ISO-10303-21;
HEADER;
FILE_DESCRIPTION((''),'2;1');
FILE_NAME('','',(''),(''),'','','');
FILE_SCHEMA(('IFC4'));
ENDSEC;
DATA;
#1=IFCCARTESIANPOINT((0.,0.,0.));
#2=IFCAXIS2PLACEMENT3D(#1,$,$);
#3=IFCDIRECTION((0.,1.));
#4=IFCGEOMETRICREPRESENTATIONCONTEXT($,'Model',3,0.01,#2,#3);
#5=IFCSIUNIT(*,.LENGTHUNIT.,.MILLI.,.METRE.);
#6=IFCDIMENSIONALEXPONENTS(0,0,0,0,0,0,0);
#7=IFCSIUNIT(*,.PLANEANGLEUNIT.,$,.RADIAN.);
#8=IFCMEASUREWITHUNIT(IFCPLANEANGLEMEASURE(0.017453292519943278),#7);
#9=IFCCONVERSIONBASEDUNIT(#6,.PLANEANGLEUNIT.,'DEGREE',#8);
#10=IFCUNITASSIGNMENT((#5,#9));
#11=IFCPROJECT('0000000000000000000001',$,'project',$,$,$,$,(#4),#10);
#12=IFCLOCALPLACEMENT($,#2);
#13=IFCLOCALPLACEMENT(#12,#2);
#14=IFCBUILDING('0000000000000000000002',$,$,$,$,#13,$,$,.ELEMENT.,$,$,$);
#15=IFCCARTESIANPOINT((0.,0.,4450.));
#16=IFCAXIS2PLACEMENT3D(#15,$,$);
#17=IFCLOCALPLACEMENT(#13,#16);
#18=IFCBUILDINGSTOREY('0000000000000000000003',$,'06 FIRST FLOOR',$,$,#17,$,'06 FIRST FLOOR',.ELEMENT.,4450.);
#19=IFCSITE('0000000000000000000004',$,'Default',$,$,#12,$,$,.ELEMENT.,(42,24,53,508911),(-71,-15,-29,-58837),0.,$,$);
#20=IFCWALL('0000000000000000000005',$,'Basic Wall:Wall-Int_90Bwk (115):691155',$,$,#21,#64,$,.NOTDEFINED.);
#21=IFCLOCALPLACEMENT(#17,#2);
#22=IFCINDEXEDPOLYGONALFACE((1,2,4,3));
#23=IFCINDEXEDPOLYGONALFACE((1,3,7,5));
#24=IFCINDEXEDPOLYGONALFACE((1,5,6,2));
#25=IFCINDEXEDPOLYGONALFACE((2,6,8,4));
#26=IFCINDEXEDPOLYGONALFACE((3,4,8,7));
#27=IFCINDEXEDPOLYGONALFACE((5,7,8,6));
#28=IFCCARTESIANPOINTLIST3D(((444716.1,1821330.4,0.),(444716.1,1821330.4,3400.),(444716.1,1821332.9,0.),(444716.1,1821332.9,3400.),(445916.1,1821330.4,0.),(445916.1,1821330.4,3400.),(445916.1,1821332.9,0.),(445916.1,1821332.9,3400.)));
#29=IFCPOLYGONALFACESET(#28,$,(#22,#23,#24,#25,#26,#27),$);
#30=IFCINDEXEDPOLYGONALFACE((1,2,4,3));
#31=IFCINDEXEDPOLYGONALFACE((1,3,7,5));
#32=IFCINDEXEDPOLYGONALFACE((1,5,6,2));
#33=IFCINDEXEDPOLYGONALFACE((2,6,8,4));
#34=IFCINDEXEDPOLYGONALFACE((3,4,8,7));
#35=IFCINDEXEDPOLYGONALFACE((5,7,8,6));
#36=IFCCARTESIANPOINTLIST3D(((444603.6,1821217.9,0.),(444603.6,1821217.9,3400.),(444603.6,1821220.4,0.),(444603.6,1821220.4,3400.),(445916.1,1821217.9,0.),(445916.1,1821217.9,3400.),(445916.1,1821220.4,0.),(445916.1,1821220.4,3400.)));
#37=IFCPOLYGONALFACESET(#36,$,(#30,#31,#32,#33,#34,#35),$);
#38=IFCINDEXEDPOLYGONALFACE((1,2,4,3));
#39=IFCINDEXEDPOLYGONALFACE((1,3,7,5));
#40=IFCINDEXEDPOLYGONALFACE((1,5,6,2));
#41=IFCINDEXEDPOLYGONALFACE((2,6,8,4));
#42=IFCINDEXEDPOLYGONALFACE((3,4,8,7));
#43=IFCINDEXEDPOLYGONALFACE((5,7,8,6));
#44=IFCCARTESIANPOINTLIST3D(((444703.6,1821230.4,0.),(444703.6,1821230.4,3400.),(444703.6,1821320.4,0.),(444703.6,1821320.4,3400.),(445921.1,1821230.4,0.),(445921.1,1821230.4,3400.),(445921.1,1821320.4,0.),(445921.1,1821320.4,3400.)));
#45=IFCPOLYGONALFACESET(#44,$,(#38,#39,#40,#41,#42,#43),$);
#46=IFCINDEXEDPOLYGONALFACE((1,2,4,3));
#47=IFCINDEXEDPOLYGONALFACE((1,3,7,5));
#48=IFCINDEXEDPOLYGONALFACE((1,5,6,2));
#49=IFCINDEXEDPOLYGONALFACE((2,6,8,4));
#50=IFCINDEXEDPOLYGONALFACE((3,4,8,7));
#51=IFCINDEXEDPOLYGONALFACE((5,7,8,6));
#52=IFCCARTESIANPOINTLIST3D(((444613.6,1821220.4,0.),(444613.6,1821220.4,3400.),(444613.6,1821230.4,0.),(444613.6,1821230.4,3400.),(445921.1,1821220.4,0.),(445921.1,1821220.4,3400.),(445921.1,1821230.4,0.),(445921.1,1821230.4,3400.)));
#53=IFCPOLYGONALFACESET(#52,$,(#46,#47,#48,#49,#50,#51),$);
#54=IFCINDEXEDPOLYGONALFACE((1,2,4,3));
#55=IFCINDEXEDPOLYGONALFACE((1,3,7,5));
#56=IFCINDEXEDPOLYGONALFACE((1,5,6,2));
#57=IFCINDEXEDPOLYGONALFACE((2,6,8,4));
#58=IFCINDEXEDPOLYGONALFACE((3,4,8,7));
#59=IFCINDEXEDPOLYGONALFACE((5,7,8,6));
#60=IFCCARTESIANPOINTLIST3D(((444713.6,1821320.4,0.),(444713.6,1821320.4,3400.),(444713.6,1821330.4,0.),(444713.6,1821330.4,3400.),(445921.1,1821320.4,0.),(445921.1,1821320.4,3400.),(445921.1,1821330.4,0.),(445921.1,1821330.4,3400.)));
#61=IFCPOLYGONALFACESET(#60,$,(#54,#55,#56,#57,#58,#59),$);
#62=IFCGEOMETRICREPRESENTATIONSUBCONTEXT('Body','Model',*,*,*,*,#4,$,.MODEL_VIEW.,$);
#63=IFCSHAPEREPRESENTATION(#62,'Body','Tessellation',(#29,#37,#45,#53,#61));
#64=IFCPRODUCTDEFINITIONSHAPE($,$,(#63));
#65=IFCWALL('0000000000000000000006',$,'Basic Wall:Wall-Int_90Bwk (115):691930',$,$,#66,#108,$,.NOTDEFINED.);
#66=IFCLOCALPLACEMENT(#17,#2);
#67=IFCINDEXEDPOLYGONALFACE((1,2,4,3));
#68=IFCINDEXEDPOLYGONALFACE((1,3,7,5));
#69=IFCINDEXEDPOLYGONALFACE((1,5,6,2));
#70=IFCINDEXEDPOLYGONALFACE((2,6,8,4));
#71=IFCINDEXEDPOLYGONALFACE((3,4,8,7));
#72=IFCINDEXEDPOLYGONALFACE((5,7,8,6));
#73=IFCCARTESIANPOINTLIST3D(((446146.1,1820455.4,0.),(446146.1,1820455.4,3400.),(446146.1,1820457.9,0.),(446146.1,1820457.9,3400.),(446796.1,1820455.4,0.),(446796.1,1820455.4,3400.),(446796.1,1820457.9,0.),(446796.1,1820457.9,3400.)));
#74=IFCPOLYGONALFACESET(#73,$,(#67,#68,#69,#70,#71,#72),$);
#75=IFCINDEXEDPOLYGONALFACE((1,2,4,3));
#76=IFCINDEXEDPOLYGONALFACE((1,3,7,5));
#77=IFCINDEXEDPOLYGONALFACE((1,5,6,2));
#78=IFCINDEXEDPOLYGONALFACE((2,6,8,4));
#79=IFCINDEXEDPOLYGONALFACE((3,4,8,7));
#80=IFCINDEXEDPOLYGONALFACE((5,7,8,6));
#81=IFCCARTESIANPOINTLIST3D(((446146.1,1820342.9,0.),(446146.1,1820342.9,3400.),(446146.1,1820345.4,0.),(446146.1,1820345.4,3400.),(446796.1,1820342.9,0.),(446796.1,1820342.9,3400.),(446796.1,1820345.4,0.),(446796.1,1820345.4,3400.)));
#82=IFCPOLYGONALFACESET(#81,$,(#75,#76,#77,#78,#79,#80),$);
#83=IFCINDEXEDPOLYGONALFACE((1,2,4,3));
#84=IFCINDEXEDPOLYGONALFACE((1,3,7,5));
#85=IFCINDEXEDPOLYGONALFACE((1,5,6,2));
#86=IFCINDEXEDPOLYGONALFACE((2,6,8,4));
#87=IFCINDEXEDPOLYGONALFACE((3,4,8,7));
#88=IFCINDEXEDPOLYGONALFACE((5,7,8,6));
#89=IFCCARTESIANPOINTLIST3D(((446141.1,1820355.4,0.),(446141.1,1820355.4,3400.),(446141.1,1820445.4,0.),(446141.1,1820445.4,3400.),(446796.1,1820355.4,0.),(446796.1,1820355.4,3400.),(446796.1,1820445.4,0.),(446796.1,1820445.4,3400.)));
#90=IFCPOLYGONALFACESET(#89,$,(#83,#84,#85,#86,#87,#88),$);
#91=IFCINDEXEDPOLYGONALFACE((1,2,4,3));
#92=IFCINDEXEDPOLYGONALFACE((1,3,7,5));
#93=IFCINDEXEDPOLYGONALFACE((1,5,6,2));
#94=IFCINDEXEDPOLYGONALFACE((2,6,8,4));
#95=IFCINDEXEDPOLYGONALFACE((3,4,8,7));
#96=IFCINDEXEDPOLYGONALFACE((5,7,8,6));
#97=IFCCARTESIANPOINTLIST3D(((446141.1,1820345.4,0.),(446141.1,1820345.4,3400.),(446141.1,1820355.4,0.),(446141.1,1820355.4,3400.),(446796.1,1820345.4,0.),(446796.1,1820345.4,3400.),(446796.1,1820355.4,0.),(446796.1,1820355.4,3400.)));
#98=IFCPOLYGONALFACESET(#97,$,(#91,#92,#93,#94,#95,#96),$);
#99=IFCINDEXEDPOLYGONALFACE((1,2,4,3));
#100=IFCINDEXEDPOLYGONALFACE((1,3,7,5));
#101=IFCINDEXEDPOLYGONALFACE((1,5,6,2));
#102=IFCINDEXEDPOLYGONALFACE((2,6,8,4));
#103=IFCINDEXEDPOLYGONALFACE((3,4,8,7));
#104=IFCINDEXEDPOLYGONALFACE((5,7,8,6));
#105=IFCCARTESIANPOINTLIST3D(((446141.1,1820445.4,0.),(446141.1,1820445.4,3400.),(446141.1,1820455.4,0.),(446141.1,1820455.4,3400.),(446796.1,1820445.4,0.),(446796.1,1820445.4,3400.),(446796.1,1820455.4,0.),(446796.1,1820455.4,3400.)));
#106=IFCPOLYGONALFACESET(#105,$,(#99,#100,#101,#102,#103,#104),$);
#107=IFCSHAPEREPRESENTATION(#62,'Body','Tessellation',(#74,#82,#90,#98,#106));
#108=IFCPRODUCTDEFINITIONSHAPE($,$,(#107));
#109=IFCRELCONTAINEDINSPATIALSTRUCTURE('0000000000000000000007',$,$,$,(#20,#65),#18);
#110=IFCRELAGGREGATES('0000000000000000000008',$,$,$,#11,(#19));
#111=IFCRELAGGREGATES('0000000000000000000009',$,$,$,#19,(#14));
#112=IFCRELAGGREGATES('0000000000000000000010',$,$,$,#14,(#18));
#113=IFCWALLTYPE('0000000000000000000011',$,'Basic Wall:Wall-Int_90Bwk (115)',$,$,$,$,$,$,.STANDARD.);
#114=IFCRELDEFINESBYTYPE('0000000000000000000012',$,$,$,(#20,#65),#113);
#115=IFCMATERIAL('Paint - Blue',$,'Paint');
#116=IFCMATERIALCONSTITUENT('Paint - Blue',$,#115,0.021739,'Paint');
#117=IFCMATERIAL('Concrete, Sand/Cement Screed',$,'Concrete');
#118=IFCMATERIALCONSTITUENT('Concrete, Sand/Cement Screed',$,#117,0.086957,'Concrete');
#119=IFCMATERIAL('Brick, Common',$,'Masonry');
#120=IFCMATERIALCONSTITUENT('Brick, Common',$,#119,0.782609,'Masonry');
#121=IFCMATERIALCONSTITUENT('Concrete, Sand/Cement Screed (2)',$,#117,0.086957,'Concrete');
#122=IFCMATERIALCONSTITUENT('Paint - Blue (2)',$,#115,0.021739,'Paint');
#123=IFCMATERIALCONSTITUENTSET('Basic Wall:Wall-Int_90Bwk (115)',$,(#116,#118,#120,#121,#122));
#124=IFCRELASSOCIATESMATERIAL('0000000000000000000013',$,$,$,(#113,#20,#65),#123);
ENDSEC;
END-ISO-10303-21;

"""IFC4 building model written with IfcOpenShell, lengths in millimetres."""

from ifc_helpers import new_model, entity, si_unit, converted_unit, direction, frame, origin, place, context, subcontext, project, spatial, indexed_curve, outline, extrude, material, constituent, constituent_set, type_object, element, save


model = new_model("IFC4")

# Units and contexts
model_context = context("Model", 3, precision=0.01, world=origin(), true_north=direction((0.0, 1.0)))
body_context = subcontext(model_context, "Body", "Model", "MODEL_VIEW")
ifc_project = project(units=[si_unit("LENGTHUNIT", "METRE", prefix="MILLI"), converted_unit("PLANEANGLEUNIT", "DEGREE", entity("IfcPlaneAngleMeasure", 0.017453292519943278), si_unit("PLANEANGLEUNIT", "RADIAN"), dimensions=[0, 0, 0, 0, 0, 0, 0])], contexts=[model_context])

# Site, building, storey
site_placement = place(None, origin())
site = spatial("IfcSite", under=ifc_project, at=site_placement, Name="Default", CompositionType="ELEMENT", RefLatitude=(42, 24, 53, 508911), RefLongitude=(-71, -15, -29, -58837), RefElevation=0.0)
building_placement = place(site_placement, origin())
building = spatial("IfcBuilding", under=site, at=building_placement, CompositionType="ELEMENT")
storey_placement = place(building_placement, frame((0.0, 0.0, 4450.0)))
storey = spatial("IfcBuildingStorey", under=building, at=storey_placement, Name="06 FIRST FLOOR", LongName="06 FIRST FLOOR", CompositionType="ELEMENT", Elevation=4450.0)

# Shared definitions
ifc_material_1 = material(Name="Paint - Blue", Category="Paint")
ifc_constituent_1 = constituent(ifc_material_1, Name="Paint - Blue", Category="Paint", fraction=0.021739)
ifc_material_2 = material(Name="Concrete, Sand/Cement Screed", Category="Concrete")
ifc_constituent_2 = constituent(ifc_material_2, Name="Concrete, Sand/Cement Screed", Category="Concrete", fraction=0.086957)
ifc_material_3 = material(Name="Brick, Common", Category="Masonry")
ifc_constituent_3 = constituent(ifc_material_3, Name="Brick, Common", Category="Masonry", fraction=0.782609)
ifc_constituent_4 = constituent(ifc_material_2, Name="Concrete, Sand/Cement Screed (2)", Category="Concrete", fraction=0.086957)
ifc_constituent_5 = constituent(ifc_material_1, Name="Paint - Blue (2)", Category="Paint", fraction=0.021739)
ifc_constituent_set_1 = constituent_set(constituents=[ifc_constituent_1, ifc_constituent_2, ifc_constituent_3, ifc_constituent_4, ifc_constituent_5], Name="Basic Wall:Wall-Int_90Bwk (115)")
wall_type_1 = type_object("IfcWallType", Name="Basic Wall:Wall-Int_90Bwk (115)", PredefinedType="STANDARD", material=ifc_constituent_set_1)

# Wall
wall_1_placement = place(storey_placement, frame((445916.1, 1821275.4, 0.0), z_axis=(0.0, 0.0, 1.0), x_axis=(-1.0, 0.0, 0.0)))
element("IfcWall", 1, at=wall_1_placement, inside=storey, type_object=wall_type_1, material=ifc_constituent_set_1, Name="Basic Wall:Wall-Int_90Bwk (115):691155", PredefinedType="NOTDEFINED", context=body_context, shape_type="SweptSolid", body=[
    extrude(outline(indexed_curve([(-1.3, -600.0), (1.2, -600.0), (1.2, 600.0), (-1.3, 600.0), (-1.3, -600.0)], self_intersect=False)), frame((600.0, -56.2, 0.0), z_axis=(0.0, 0.0, 1.0), x_axis=(0.0, 1.0, 0.0)), (0.0, 0.0, 1.0), 3400.0),
    extrude(outline(indexed_curve([(-1.3, -656.2), (1.3, -656.2), (1.3, 656.2), (-1.3, 656.2), (-1.3, -656.2)], self_intersect=False)), frame((656.2, 56.3, 0.0), z_axis=(0.0, 0.0, 1.0), x_axis=(0.0, -1.0, 0.0)), (0.0, 0.0, 1.0), 3400.0),
    extrude(outline(indexed_curve([(-608.7, -45.0), (608.7, -45.0), (608.7, 45.0), (-608.7, 45.0), (-608.7, -45.0)], self_intersect=False)), frame((603.7, 0.0, 0.0)), (0.0, 0.0, 1.0), 3400.0),
    extrude(outline(indexed_curve([(-653.7, -5.0), (653.7, -5.0), (653.7, 5.0), (-653.7, 5.0), (-653.7, -5.0)], self_intersect=False)), frame((648.7, 50.0, 0.0)), (0.0, 0.0, 1.0), 3400.0),
    extrude(outline(indexed_curve([(-603.7, -5.0), (603.7, -5.0), (603.7, 5.0), (-603.7, 5.0), (-603.7, -5.0)], self_intersect=False)), frame((598.7, -50.0, 0.0)), (0.0, 0.0, 1.0), 3400.0),
])

# Wall
wall_2_placement = place(storey_placement, frame((446796.1, 1820400.4, 0.0), z_axis=(0.0, 0.0, 1.0), x_axis=(-1.0, 0.0, 0.0)))
element("IfcWall", 2, at=wall_2_placement, inside=storey, type_object=wall_type_1, material=ifc_constituent_set_1, Name="Basic Wall:Wall-Int_90Bwk (115):691930", PredefinedType="NOTDEFINED", context=body_context, shape_type="SweptSolid", body=[
    extrude(outline(indexed_curve([(-1.2, -325.0), (1.3, -325.0), (1.3, 325.0), (-1.2, 325.0), (-1.2, -325.0)], self_intersect=False)), frame((325.0, -56.3, 0.0), z_axis=(0.0, 0.0, 1.0), x_axis=(0.0, 1.0, 0.0)), (0.0, 0.0, 1.0), 3400.0),
    extrude(outline(indexed_curve([(-1.3, -325.0), (1.3, -325.0), (1.3, 325.0), (-1.3, 325.0), (-1.3, -325.0)], self_intersect=False)), frame((325.0, 56.3, 0.0), z_axis=(0.0, 0.0, 1.0), x_axis=(0.0, -1.0, 0.0)), (0.0, 0.0, 1.0), 3400.0),
    extrude(outline(indexed_curve([(-327.5, -45.0), (327.5, -45.0), (327.5, 45.0), (-327.5, 45.0), (-327.5, -45.0)], self_intersect=False)), frame((327.5, 0.0, 0.0)), (0.0, 0.0, 1.0), 3400.0),
    extrude(outline(indexed_curve([(-327.5, -5.0), (327.5, -5.0), (327.5, 5.0), (-327.5, 5.0), (-327.5, -5.0)], self_intersect=False)), frame((327.5, 50.0, 0.0)), (0.0, 0.0, 1.0), 3400.0),
    extrude(outline(indexed_curve([(-327.5, -5.0), (327.5, -5.0), (327.5, 5.0), (-327.5, 5.0), (-327.5, -5.0)], self_intersect=False)), frame((327.5, -50.0, 0.0)), (0.0, 0.0, 1.0), 3400.0),
])

save(model, "model.ifc")
